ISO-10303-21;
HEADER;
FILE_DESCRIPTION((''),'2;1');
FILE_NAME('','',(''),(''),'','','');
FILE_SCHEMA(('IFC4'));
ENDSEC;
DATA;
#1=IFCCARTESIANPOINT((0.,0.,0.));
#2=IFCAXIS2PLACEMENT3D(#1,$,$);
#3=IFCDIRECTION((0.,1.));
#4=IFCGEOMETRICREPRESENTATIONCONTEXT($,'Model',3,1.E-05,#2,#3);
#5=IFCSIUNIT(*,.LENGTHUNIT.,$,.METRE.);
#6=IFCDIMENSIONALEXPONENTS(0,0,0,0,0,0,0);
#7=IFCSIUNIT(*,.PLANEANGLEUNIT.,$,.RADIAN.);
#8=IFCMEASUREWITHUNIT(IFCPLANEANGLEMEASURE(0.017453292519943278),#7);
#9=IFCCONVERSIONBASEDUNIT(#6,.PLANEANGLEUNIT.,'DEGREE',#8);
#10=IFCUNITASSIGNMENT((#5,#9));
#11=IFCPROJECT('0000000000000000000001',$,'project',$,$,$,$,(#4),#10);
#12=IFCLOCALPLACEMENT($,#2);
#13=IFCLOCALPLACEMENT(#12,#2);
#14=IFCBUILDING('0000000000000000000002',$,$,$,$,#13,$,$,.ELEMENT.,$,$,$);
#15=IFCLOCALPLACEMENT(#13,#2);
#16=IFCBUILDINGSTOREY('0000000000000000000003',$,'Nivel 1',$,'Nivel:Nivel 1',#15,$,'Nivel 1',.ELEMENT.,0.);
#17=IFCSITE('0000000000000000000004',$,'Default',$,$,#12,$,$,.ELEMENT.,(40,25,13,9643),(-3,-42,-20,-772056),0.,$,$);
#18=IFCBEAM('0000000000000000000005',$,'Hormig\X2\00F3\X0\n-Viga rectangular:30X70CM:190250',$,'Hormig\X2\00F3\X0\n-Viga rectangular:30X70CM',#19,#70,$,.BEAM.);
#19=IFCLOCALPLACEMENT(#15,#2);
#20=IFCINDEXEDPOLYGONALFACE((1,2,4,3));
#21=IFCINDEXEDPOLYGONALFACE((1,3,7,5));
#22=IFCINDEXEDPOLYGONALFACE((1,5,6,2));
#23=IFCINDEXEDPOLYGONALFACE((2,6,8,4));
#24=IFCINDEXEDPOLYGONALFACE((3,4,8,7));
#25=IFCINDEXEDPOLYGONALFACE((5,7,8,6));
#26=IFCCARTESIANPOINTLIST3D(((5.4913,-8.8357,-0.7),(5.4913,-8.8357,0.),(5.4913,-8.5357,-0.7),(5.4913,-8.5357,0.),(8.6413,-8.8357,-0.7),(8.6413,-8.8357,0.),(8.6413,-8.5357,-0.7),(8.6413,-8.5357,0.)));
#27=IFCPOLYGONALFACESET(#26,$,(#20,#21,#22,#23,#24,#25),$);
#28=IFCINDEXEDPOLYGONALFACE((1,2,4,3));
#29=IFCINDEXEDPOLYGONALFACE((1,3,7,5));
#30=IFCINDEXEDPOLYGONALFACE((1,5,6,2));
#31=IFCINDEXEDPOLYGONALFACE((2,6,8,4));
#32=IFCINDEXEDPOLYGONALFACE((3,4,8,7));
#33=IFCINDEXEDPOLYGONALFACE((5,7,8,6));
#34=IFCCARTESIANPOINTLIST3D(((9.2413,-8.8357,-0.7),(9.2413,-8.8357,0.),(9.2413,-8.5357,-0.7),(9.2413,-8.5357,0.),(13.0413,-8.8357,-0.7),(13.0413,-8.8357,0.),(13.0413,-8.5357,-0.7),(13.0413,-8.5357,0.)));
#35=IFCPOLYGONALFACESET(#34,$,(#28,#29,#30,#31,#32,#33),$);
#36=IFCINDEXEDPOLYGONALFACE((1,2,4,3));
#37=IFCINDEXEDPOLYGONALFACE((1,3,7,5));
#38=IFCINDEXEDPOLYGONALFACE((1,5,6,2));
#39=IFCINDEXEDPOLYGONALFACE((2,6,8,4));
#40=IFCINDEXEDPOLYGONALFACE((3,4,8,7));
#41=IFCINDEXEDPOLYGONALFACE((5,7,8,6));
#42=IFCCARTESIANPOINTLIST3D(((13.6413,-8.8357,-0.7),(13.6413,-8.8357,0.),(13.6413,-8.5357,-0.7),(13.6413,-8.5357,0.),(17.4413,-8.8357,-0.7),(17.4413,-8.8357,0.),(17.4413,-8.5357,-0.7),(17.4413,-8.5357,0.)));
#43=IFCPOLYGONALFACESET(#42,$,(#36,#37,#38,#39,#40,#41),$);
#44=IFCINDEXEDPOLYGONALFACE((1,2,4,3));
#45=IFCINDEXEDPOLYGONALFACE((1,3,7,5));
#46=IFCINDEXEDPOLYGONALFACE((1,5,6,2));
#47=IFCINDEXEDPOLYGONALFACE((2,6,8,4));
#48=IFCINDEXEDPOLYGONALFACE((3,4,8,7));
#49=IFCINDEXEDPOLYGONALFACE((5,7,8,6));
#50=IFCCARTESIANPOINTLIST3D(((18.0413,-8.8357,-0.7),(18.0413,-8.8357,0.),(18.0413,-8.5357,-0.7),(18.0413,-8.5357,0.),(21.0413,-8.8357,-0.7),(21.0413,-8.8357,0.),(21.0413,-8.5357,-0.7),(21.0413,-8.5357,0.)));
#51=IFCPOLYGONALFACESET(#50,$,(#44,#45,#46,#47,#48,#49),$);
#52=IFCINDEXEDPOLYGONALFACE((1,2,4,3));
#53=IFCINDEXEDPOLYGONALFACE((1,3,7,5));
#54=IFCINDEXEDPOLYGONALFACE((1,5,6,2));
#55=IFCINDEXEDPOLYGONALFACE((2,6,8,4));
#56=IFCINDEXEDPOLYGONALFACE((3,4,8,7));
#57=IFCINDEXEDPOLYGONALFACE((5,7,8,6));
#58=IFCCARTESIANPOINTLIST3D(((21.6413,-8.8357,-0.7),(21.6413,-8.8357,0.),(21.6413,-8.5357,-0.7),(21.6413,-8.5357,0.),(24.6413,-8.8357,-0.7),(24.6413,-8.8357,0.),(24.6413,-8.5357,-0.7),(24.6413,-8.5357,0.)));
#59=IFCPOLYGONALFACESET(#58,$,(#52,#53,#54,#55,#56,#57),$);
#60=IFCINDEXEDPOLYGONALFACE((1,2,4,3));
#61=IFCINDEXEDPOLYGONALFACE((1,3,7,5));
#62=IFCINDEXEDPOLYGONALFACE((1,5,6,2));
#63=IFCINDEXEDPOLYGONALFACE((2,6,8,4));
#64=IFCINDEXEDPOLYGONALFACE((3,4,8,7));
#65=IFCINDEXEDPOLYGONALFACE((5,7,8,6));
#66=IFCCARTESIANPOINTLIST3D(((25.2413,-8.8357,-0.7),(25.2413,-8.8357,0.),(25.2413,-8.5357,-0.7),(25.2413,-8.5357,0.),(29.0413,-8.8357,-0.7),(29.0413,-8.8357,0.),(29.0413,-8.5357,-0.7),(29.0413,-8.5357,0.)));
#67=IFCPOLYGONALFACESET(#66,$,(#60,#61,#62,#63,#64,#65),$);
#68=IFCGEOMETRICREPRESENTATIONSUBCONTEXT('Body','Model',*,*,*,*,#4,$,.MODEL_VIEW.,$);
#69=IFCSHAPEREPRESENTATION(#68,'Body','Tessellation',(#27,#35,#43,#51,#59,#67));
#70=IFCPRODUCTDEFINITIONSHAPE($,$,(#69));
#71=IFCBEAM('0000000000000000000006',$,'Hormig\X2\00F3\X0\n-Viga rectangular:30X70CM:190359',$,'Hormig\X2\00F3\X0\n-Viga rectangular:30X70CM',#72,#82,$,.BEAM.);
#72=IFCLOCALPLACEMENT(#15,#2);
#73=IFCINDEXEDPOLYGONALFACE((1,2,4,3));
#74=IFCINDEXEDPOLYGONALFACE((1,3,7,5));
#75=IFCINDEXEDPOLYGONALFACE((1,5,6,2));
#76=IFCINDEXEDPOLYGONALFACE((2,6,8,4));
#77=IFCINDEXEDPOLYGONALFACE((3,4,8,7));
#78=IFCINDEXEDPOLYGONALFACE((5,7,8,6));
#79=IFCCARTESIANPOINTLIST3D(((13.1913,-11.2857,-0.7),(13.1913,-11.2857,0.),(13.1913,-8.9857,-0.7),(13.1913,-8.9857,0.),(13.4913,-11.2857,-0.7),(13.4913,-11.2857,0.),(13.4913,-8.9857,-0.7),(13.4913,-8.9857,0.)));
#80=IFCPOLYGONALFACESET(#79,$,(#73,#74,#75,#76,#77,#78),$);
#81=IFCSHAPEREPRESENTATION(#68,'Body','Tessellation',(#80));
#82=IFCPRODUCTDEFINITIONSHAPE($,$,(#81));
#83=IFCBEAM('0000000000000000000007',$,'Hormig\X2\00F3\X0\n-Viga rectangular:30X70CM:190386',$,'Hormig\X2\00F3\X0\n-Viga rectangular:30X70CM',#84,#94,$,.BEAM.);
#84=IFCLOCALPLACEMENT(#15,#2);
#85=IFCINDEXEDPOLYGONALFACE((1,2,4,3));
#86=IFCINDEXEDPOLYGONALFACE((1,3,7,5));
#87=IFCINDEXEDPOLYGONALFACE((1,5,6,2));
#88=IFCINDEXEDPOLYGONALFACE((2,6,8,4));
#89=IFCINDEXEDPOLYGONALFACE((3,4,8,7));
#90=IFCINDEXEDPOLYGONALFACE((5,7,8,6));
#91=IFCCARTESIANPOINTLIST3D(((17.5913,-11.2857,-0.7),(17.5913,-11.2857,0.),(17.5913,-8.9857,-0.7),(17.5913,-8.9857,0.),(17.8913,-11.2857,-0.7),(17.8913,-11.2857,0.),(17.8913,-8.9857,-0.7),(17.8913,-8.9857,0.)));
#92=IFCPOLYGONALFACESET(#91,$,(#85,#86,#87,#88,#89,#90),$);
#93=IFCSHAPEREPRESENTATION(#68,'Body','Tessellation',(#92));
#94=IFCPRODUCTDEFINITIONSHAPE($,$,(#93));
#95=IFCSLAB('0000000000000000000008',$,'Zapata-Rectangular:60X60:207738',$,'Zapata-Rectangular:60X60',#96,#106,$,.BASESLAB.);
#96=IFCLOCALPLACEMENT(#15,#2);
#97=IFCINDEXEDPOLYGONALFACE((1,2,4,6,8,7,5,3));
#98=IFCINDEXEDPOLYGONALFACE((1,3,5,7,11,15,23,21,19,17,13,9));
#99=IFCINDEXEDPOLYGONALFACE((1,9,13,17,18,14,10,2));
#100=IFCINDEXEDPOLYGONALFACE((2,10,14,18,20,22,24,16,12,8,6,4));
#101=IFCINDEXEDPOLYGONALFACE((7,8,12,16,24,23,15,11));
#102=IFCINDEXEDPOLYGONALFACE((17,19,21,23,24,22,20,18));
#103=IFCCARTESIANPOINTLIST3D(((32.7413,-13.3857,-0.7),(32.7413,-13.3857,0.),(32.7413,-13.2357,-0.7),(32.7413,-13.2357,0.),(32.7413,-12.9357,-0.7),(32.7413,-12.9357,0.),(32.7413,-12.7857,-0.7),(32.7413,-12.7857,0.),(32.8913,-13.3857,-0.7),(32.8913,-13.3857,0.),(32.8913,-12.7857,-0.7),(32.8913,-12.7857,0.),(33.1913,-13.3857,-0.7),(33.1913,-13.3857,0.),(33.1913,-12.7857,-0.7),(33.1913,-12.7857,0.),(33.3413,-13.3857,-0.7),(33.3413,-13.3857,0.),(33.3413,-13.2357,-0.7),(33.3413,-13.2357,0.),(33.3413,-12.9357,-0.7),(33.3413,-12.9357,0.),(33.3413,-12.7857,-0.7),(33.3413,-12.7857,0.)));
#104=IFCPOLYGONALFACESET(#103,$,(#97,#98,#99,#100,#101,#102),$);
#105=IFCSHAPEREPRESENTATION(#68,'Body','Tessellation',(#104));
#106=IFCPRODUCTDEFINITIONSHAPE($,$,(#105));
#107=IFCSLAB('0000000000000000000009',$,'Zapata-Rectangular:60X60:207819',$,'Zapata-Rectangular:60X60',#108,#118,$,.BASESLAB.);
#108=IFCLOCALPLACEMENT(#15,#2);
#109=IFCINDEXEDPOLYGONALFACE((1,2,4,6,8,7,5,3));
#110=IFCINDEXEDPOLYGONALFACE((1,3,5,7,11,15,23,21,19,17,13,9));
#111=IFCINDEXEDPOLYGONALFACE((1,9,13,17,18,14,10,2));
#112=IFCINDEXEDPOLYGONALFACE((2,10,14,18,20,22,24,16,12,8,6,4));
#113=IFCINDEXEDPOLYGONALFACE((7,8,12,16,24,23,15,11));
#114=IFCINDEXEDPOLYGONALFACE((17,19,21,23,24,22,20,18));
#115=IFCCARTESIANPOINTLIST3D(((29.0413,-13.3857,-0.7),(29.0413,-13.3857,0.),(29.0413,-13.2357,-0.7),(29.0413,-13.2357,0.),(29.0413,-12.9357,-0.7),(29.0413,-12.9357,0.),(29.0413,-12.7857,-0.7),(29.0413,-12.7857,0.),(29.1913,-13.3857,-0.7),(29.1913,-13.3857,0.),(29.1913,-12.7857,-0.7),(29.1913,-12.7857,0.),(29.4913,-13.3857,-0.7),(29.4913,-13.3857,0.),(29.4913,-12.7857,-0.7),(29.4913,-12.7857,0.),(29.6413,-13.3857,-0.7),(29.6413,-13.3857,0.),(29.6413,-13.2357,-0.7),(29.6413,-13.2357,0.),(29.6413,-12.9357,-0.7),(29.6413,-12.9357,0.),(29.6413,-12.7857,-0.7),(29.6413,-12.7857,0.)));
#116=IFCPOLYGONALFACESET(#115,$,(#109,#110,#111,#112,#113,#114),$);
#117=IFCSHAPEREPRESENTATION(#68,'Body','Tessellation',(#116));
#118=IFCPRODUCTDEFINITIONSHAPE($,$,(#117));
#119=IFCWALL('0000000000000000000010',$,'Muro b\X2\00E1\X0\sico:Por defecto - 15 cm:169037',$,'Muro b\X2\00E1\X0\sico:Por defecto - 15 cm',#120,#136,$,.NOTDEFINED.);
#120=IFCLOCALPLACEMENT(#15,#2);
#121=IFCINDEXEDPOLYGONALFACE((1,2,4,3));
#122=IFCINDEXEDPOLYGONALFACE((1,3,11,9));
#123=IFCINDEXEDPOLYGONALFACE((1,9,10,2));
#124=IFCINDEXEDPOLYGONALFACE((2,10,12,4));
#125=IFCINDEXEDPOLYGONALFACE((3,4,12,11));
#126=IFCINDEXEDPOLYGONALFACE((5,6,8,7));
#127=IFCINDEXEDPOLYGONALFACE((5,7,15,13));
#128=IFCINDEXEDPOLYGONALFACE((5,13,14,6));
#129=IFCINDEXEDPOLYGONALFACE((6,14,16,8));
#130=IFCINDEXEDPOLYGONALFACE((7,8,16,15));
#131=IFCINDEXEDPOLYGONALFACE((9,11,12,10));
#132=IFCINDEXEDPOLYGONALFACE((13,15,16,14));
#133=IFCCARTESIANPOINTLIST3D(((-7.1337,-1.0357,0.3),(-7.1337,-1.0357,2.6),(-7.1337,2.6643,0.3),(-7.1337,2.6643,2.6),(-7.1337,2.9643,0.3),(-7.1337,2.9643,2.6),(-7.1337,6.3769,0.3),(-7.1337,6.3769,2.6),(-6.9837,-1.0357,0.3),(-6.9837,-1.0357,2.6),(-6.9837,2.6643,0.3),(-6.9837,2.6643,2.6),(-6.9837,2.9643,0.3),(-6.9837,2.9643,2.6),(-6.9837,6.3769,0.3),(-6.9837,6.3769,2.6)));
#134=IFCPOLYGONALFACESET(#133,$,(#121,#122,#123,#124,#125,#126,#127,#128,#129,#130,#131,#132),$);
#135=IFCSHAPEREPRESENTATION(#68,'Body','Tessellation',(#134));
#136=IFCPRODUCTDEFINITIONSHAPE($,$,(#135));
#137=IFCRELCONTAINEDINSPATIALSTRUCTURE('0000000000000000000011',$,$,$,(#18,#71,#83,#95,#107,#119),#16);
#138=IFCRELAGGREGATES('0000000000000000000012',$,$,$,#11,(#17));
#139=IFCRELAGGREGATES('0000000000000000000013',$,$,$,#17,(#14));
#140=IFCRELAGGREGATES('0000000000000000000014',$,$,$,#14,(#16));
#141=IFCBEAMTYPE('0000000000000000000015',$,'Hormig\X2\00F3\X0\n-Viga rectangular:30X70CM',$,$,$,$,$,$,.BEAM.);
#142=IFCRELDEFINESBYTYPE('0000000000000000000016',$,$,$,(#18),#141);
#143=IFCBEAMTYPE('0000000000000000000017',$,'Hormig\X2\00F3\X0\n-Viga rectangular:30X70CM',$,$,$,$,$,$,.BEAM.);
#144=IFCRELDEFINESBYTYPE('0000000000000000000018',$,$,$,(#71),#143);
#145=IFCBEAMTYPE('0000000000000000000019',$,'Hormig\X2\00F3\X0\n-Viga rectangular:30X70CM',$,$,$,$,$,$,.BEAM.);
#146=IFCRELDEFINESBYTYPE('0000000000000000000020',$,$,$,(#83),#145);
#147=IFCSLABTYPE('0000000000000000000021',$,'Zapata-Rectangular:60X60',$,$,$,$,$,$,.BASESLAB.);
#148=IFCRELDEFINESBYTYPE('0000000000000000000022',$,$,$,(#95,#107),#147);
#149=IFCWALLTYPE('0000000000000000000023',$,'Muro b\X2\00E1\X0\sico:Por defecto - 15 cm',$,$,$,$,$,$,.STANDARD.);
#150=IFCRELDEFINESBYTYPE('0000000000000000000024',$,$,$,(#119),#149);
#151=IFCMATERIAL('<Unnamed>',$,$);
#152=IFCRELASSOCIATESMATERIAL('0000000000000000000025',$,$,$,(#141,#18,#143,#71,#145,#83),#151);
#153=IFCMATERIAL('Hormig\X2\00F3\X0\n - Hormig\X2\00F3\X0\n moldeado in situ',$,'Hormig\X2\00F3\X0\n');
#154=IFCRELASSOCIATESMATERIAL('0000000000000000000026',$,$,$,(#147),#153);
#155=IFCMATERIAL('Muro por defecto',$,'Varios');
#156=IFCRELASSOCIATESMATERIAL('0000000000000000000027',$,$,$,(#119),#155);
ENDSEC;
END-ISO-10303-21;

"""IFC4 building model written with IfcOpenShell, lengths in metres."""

from ifc_helpers import new_model, entity, si_unit, converted_unit, direction, frame, origin, place, context, subcontext, project, spatial, indexed_curve, outline, extrude, source, transform, mapped, material, type_object, type_shapes, element, save


model = new_model("IFC4")

# Units and contexts
model_context = context("Model", 3, precision=1e-05, world=origin(), true_north=direction((0.0, 1.0)))
body_context = subcontext(model_context, "Body", "Model", "MODEL_VIEW")
ifc_project = project(units=[si_unit("LENGTHUNIT", "METRE"), converted_unit("PLANEANGLEUNIT", "DEGREE", entity("IfcPlaneAngleMeasure", 0.017453292519943278), si_unit("PLANEANGLEUNIT", "RADIAN"), dimensions=[0, 0, 0, 0, 0, 0, 0])], contexts=[model_context])

# Site, building, storey
site_placement = place(None, origin())
site = spatial("IfcSite", under=ifc_project, at=site_placement, Name="Default", CompositionType="ELEMENT", RefLatitude=(40, 25, 13, 9643), RefLongitude=(-3, -42, -20, -772056), RefElevation=0.0)
building_placement = place(site_placement, origin())
building = spatial("IfcBuilding", under=site, at=building_placement, CompositionType="ELEMENT")
storey_placement = place(building_placement, origin())
storey = spatial("IfcBuildingStorey", under=building, at=storey_placement, Name="Nivel 1", ObjectType="Nivel:Nivel 1", LongName="Nivel 1", CompositionType="ELEMENT", Elevation=0.0)

# Beams
ifc_material_1 = material(Name="<Unnamed>")
beam_type_1 = type_object("IfcBeamType", Name="Hormigón-Viga rectangular:30X70CM", PredefinedType="BEAM", material=ifc_material_1)
shared_shape_1 = source(origin(), body_context, "Body", "SweptSolid", [
    extrude(outline(indexed_curve([(-0.35, -0.15), (0.35, -0.15), (0.35, 0.15), (-0.35, 0.15), (-0.35, -0.15)], self_intersect=False)), frame((8.6413, -8.6857, -0.35), z_axis=(-1.0, 0.0, 0.0), x_axis=(0.0, 0.0, -1.0)), (0.0, 0.0, 1.0), 3.15),
    extrude(outline(indexed_curve([(-0.35, -0.15), (0.35, -0.15), (0.35, 0.15), (-0.35, 0.15), (-0.35, -0.15)], self_intersect=False)), frame((13.0413, -8.6857, -0.35), z_axis=(-1.0, 0.0, 0.0), x_axis=(0.0, 0.0, -1.0)), (0.0, 0.0, 1.0), 3.8),
    extrude(outline(indexed_curve([(-0.35, -0.15), (0.35, -0.15), (0.35, 0.15), (-0.35, 0.15), (-0.35, -0.15)], self_intersect=False)), frame((17.4413, -8.6857, -0.35), z_axis=(-1.0, 0.0, 0.0), x_axis=(0.0, 0.0, -1.0)), (0.0, 0.0, 1.0), 3.8),
    extrude(outline(indexed_curve([(-0.35, -0.15), (0.35, -0.15), (0.35, 0.15), (-0.35, 0.15), (-0.35, -0.15)], self_intersect=False)), frame((21.0413, -8.6857, -0.35), z_axis=(-1.0, 0.0, 0.0), x_axis=(0.0, 0.0, -1.0)), (0.0, 0.0, 1.0), 3.0),
    extrude(outline(indexed_curve([(-0.35, -0.15), (0.35, -0.15), (0.35, 0.15), (-0.35, 0.15), (-0.35, -0.15)], self_intersect=False)), frame((24.6413, -8.6857, -0.35), z_axis=(-1.0, 0.0, 0.0), x_axis=(0.0, 0.0, -1.0)), (0.0, 0.0, 1.0), 3.0),
    extrude(outline(indexed_curve([(-0.35, -0.15), (0.35, -0.15), (0.35, 0.15), (-0.35, 0.15), (-0.35, -0.15)], self_intersect=False)), frame((29.0413, -8.6857, -0.35), z_axis=(-1.0, 0.0, 0.0), x_axis=(0.0, 0.0, -1.0)), (0.0, 0.0, 1.0), 3.8),
])
type_shapes(beam_type_1, [shared_shape_1])
beam_1_placement = place(storey_placement, origin())
element("IfcBeam", 1, at=beam_1_placement, inside=storey, type_object=beam_type_1, material=ifc_material_1, Name="Hormigón-Viga rectangular:30X70CM:190250", ObjectType="Hormigón-Viga rectangular:30X70CM", PredefinedType="BEAM", context=body_context, shape_type="MappedRepresentation", body=[
    mapped(shared_shape_1, transform((0.0, 0.0, 0.0), scale=1.0)),
])
beam_type_2 = type_object("IfcBeamType", Name="Hormigón-Viga rectangular:30X70CM", PredefinedType="BEAM", material=ifc_material_1)
shared_shape_2 = source(origin(), body_context, "Body", "SweptSolid", [
    extrude(outline(indexed_curve([(-0.15, -0.35), (0.15, -0.35), (0.15, 0.35), (-0.15, 0.35), (-0.15, -0.35)], self_intersect=False)), frame((13.3413, -8.9857, -0.35), z_axis=(0.0, -1.0, 0.0), x_axis=(-1.0, 0.0, 0.0)), (0.0, 0.0, 1.0), 2.3),
])
type_shapes(beam_type_2, [shared_shape_2])
beam_2_placement = place(storey_placement, origin())
element("IfcBeam", 2, at=beam_2_placement, inside=storey, type_object=beam_type_2, material=ifc_material_1, Name="Hormigón-Viga rectangular:30X70CM:190359", ObjectType="Hormigón-Viga rectangular:30X70CM", PredefinedType="BEAM", context=body_context, shape_type="MappedRepresentation", body=[
    mapped(shared_shape_2, transform((0.0, 0.0, 0.0), scale=1.0)),
])
beam_type_3 = type_object("IfcBeamType", Name="Hormigón-Viga rectangular:30X70CM", PredefinedType="BEAM", material=ifc_material_1)
shared_shape_3 = source(origin(), body_context, "Body", "SweptSolid", [
    extrude(outline(indexed_curve([(-0.15, -0.35), (0.15, -0.35), (0.15, 0.35), (-0.15, 0.35), (-0.15, -0.35)], self_intersect=False)), frame((17.7413, -8.9857, -0.35), z_axis=(0.0, -1.0, 0.0), x_axis=(-1.0, 0.0, 0.0)), (0.0, 0.0, 1.0), 2.3),
])
type_shapes(beam_type_3, [shared_shape_3])
beam_3_placement = place(storey_placement, origin())
element("IfcBeam", 3, at=beam_3_placement, inside=storey, type_object=beam_type_3, material=ifc_material_1, Name="Hormigón-Viga rectangular:30X70CM:190386", ObjectType="Hormigón-Viga rectangular:30X70CM", PredefinedType="BEAM", context=body_context, shape_type="MappedRepresentation", body=[
    mapped(shared_shape_3, transform((0.0, 0.0, 0.0), scale=1.0)),
])

# Slabs
ifc_material_2 = material(Name="Hormigón - Hormigón moldeado in situ", Category="Hormigón")
slab_type_1 = type_object("IfcSlabType", Name="Zapata-Rectangular:60X60", PredefinedType="BASESLAB", material=ifc_material_2)
slab_1_placement = place(storey_placement, origin())
element("IfcSlab", 4, at=slab_1_placement, inside=storey, type_object=slab_type_1, Name="Zapata-Rectangular:60X60:207738", ObjectType="Zapata-Rectangular:60X60", PredefinedType="BASESLAB", context=body_context, shape_type="SweptSolid", body=[
    extrude(outline(indexed_curve([(-0.3, -0.3), (-0.15, -0.3), (0.15, -0.3), (0.3, -0.3), (0.3, -0.15), (0.3, 0.15), (0.3, 0.3), (0.15, 0.3), (-0.15, 0.3), (-0.3, 0.3), (-0.3, 0.15), (-0.3, -0.15), (-0.3, -0.3)], self_intersect=False)), frame((33.0413, -13.0857, -0.7), z_axis=(0.0, 0.0, 1.0), x_axis=(-1.0, 0.0, 0.0)), (0.0, 0.0, 1.0), 0.7),
])
slab_2_placement = place(storey_placement, origin())
element("IfcSlab", 5, at=slab_2_placement, inside=storey, type_object=slab_type_1, Name="Zapata-Rectangular:60X60:207819", ObjectType="Zapata-Rectangular:60X60", PredefinedType="BASESLAB", context=body_context, shape_type="SweptSolid", body=[
    extrude(outline(indexed_curve([(-0.3, -0.3), (-0.15, -0.3), (0.15, -0.3), (0.3, -0.3), (0.3, -0.15), (0.3, 0.15), (0.3, 0.3), (0.15, 0.3), (-0.15, 0.3), (-0.3, 0.3), (-0.3, 0.15), (-0.3, -0.15), (-0.3, -0.3)], self_intersect=False)), frame((29.3413, -13.0857, -0.7), z_axis=(0.0, 0.0, 1.0), x_axis=(-1.0, 0.0, 0.0)), (0.0, 0.0, 1.0), 0.7),
])

# Wall, opening
ifc_material_3 = material(Name="Muro por defecto", Category="Varios")
wall_type = type_object("IfcWallType", Name="Muro básico:Por defecto - 15 cm", PredefinedType="STANDARD")
wall_placement = place(storey_placement, frame((-7.0587, 6.3769, 0.3), z_axis=(0.0, 0.0, 1.0), x_axis=(0.0, -1.0, 0.0)))
wall = element("IfcWall", 6, at=wall_placement, inside=storey, type_object=wall_type, material=ifc_material_3, Name="Muro básico:Por defecto - 15 cm:169037", ObjectType="Muro básico:Por defecto - 15 cm", PredefinedType="NOTDEFINED", context=body_context, shape_type="SweptSolid", body=[
    extrude(outline(indexed_curve([(7.4126, 0.075), (0.0, 0.075), (0.0, -0.075), (7.4126, -0.075), (7.4126, 0.075)], self_intersect=False)), origin(), (0.0, 0.0, 1.0), 2.3),
])
opening_placement = place(storey_placement, frame((-7.0587, 6.3769, 0.3), z_axis=(0.0, 0.0, 1.0), x_axis=(0.0, -1.0, 0.0)))
element("IfcOpeningElement", 7, at=opening_placement, cuts=wall, PredefinedType="OPENING", context=body_context, shape_type="SweptSolid", body=[
    extrude(outline(indexed_curve([(-1.15, -0.075), (1.15, -0.075), (1.15, 0.075), (-1.15, 0.075), (-1.15, -0.075)], self_intersect=False)), frame((3.7126, 0.0, 1.15), z_axis=(-1.0, 0.0, 0.0), x_axis=(0.0, 0.0, 1.0)), (0.0, 0.0, 1.0), 0.3),
])

save(model, "model.ifc")
